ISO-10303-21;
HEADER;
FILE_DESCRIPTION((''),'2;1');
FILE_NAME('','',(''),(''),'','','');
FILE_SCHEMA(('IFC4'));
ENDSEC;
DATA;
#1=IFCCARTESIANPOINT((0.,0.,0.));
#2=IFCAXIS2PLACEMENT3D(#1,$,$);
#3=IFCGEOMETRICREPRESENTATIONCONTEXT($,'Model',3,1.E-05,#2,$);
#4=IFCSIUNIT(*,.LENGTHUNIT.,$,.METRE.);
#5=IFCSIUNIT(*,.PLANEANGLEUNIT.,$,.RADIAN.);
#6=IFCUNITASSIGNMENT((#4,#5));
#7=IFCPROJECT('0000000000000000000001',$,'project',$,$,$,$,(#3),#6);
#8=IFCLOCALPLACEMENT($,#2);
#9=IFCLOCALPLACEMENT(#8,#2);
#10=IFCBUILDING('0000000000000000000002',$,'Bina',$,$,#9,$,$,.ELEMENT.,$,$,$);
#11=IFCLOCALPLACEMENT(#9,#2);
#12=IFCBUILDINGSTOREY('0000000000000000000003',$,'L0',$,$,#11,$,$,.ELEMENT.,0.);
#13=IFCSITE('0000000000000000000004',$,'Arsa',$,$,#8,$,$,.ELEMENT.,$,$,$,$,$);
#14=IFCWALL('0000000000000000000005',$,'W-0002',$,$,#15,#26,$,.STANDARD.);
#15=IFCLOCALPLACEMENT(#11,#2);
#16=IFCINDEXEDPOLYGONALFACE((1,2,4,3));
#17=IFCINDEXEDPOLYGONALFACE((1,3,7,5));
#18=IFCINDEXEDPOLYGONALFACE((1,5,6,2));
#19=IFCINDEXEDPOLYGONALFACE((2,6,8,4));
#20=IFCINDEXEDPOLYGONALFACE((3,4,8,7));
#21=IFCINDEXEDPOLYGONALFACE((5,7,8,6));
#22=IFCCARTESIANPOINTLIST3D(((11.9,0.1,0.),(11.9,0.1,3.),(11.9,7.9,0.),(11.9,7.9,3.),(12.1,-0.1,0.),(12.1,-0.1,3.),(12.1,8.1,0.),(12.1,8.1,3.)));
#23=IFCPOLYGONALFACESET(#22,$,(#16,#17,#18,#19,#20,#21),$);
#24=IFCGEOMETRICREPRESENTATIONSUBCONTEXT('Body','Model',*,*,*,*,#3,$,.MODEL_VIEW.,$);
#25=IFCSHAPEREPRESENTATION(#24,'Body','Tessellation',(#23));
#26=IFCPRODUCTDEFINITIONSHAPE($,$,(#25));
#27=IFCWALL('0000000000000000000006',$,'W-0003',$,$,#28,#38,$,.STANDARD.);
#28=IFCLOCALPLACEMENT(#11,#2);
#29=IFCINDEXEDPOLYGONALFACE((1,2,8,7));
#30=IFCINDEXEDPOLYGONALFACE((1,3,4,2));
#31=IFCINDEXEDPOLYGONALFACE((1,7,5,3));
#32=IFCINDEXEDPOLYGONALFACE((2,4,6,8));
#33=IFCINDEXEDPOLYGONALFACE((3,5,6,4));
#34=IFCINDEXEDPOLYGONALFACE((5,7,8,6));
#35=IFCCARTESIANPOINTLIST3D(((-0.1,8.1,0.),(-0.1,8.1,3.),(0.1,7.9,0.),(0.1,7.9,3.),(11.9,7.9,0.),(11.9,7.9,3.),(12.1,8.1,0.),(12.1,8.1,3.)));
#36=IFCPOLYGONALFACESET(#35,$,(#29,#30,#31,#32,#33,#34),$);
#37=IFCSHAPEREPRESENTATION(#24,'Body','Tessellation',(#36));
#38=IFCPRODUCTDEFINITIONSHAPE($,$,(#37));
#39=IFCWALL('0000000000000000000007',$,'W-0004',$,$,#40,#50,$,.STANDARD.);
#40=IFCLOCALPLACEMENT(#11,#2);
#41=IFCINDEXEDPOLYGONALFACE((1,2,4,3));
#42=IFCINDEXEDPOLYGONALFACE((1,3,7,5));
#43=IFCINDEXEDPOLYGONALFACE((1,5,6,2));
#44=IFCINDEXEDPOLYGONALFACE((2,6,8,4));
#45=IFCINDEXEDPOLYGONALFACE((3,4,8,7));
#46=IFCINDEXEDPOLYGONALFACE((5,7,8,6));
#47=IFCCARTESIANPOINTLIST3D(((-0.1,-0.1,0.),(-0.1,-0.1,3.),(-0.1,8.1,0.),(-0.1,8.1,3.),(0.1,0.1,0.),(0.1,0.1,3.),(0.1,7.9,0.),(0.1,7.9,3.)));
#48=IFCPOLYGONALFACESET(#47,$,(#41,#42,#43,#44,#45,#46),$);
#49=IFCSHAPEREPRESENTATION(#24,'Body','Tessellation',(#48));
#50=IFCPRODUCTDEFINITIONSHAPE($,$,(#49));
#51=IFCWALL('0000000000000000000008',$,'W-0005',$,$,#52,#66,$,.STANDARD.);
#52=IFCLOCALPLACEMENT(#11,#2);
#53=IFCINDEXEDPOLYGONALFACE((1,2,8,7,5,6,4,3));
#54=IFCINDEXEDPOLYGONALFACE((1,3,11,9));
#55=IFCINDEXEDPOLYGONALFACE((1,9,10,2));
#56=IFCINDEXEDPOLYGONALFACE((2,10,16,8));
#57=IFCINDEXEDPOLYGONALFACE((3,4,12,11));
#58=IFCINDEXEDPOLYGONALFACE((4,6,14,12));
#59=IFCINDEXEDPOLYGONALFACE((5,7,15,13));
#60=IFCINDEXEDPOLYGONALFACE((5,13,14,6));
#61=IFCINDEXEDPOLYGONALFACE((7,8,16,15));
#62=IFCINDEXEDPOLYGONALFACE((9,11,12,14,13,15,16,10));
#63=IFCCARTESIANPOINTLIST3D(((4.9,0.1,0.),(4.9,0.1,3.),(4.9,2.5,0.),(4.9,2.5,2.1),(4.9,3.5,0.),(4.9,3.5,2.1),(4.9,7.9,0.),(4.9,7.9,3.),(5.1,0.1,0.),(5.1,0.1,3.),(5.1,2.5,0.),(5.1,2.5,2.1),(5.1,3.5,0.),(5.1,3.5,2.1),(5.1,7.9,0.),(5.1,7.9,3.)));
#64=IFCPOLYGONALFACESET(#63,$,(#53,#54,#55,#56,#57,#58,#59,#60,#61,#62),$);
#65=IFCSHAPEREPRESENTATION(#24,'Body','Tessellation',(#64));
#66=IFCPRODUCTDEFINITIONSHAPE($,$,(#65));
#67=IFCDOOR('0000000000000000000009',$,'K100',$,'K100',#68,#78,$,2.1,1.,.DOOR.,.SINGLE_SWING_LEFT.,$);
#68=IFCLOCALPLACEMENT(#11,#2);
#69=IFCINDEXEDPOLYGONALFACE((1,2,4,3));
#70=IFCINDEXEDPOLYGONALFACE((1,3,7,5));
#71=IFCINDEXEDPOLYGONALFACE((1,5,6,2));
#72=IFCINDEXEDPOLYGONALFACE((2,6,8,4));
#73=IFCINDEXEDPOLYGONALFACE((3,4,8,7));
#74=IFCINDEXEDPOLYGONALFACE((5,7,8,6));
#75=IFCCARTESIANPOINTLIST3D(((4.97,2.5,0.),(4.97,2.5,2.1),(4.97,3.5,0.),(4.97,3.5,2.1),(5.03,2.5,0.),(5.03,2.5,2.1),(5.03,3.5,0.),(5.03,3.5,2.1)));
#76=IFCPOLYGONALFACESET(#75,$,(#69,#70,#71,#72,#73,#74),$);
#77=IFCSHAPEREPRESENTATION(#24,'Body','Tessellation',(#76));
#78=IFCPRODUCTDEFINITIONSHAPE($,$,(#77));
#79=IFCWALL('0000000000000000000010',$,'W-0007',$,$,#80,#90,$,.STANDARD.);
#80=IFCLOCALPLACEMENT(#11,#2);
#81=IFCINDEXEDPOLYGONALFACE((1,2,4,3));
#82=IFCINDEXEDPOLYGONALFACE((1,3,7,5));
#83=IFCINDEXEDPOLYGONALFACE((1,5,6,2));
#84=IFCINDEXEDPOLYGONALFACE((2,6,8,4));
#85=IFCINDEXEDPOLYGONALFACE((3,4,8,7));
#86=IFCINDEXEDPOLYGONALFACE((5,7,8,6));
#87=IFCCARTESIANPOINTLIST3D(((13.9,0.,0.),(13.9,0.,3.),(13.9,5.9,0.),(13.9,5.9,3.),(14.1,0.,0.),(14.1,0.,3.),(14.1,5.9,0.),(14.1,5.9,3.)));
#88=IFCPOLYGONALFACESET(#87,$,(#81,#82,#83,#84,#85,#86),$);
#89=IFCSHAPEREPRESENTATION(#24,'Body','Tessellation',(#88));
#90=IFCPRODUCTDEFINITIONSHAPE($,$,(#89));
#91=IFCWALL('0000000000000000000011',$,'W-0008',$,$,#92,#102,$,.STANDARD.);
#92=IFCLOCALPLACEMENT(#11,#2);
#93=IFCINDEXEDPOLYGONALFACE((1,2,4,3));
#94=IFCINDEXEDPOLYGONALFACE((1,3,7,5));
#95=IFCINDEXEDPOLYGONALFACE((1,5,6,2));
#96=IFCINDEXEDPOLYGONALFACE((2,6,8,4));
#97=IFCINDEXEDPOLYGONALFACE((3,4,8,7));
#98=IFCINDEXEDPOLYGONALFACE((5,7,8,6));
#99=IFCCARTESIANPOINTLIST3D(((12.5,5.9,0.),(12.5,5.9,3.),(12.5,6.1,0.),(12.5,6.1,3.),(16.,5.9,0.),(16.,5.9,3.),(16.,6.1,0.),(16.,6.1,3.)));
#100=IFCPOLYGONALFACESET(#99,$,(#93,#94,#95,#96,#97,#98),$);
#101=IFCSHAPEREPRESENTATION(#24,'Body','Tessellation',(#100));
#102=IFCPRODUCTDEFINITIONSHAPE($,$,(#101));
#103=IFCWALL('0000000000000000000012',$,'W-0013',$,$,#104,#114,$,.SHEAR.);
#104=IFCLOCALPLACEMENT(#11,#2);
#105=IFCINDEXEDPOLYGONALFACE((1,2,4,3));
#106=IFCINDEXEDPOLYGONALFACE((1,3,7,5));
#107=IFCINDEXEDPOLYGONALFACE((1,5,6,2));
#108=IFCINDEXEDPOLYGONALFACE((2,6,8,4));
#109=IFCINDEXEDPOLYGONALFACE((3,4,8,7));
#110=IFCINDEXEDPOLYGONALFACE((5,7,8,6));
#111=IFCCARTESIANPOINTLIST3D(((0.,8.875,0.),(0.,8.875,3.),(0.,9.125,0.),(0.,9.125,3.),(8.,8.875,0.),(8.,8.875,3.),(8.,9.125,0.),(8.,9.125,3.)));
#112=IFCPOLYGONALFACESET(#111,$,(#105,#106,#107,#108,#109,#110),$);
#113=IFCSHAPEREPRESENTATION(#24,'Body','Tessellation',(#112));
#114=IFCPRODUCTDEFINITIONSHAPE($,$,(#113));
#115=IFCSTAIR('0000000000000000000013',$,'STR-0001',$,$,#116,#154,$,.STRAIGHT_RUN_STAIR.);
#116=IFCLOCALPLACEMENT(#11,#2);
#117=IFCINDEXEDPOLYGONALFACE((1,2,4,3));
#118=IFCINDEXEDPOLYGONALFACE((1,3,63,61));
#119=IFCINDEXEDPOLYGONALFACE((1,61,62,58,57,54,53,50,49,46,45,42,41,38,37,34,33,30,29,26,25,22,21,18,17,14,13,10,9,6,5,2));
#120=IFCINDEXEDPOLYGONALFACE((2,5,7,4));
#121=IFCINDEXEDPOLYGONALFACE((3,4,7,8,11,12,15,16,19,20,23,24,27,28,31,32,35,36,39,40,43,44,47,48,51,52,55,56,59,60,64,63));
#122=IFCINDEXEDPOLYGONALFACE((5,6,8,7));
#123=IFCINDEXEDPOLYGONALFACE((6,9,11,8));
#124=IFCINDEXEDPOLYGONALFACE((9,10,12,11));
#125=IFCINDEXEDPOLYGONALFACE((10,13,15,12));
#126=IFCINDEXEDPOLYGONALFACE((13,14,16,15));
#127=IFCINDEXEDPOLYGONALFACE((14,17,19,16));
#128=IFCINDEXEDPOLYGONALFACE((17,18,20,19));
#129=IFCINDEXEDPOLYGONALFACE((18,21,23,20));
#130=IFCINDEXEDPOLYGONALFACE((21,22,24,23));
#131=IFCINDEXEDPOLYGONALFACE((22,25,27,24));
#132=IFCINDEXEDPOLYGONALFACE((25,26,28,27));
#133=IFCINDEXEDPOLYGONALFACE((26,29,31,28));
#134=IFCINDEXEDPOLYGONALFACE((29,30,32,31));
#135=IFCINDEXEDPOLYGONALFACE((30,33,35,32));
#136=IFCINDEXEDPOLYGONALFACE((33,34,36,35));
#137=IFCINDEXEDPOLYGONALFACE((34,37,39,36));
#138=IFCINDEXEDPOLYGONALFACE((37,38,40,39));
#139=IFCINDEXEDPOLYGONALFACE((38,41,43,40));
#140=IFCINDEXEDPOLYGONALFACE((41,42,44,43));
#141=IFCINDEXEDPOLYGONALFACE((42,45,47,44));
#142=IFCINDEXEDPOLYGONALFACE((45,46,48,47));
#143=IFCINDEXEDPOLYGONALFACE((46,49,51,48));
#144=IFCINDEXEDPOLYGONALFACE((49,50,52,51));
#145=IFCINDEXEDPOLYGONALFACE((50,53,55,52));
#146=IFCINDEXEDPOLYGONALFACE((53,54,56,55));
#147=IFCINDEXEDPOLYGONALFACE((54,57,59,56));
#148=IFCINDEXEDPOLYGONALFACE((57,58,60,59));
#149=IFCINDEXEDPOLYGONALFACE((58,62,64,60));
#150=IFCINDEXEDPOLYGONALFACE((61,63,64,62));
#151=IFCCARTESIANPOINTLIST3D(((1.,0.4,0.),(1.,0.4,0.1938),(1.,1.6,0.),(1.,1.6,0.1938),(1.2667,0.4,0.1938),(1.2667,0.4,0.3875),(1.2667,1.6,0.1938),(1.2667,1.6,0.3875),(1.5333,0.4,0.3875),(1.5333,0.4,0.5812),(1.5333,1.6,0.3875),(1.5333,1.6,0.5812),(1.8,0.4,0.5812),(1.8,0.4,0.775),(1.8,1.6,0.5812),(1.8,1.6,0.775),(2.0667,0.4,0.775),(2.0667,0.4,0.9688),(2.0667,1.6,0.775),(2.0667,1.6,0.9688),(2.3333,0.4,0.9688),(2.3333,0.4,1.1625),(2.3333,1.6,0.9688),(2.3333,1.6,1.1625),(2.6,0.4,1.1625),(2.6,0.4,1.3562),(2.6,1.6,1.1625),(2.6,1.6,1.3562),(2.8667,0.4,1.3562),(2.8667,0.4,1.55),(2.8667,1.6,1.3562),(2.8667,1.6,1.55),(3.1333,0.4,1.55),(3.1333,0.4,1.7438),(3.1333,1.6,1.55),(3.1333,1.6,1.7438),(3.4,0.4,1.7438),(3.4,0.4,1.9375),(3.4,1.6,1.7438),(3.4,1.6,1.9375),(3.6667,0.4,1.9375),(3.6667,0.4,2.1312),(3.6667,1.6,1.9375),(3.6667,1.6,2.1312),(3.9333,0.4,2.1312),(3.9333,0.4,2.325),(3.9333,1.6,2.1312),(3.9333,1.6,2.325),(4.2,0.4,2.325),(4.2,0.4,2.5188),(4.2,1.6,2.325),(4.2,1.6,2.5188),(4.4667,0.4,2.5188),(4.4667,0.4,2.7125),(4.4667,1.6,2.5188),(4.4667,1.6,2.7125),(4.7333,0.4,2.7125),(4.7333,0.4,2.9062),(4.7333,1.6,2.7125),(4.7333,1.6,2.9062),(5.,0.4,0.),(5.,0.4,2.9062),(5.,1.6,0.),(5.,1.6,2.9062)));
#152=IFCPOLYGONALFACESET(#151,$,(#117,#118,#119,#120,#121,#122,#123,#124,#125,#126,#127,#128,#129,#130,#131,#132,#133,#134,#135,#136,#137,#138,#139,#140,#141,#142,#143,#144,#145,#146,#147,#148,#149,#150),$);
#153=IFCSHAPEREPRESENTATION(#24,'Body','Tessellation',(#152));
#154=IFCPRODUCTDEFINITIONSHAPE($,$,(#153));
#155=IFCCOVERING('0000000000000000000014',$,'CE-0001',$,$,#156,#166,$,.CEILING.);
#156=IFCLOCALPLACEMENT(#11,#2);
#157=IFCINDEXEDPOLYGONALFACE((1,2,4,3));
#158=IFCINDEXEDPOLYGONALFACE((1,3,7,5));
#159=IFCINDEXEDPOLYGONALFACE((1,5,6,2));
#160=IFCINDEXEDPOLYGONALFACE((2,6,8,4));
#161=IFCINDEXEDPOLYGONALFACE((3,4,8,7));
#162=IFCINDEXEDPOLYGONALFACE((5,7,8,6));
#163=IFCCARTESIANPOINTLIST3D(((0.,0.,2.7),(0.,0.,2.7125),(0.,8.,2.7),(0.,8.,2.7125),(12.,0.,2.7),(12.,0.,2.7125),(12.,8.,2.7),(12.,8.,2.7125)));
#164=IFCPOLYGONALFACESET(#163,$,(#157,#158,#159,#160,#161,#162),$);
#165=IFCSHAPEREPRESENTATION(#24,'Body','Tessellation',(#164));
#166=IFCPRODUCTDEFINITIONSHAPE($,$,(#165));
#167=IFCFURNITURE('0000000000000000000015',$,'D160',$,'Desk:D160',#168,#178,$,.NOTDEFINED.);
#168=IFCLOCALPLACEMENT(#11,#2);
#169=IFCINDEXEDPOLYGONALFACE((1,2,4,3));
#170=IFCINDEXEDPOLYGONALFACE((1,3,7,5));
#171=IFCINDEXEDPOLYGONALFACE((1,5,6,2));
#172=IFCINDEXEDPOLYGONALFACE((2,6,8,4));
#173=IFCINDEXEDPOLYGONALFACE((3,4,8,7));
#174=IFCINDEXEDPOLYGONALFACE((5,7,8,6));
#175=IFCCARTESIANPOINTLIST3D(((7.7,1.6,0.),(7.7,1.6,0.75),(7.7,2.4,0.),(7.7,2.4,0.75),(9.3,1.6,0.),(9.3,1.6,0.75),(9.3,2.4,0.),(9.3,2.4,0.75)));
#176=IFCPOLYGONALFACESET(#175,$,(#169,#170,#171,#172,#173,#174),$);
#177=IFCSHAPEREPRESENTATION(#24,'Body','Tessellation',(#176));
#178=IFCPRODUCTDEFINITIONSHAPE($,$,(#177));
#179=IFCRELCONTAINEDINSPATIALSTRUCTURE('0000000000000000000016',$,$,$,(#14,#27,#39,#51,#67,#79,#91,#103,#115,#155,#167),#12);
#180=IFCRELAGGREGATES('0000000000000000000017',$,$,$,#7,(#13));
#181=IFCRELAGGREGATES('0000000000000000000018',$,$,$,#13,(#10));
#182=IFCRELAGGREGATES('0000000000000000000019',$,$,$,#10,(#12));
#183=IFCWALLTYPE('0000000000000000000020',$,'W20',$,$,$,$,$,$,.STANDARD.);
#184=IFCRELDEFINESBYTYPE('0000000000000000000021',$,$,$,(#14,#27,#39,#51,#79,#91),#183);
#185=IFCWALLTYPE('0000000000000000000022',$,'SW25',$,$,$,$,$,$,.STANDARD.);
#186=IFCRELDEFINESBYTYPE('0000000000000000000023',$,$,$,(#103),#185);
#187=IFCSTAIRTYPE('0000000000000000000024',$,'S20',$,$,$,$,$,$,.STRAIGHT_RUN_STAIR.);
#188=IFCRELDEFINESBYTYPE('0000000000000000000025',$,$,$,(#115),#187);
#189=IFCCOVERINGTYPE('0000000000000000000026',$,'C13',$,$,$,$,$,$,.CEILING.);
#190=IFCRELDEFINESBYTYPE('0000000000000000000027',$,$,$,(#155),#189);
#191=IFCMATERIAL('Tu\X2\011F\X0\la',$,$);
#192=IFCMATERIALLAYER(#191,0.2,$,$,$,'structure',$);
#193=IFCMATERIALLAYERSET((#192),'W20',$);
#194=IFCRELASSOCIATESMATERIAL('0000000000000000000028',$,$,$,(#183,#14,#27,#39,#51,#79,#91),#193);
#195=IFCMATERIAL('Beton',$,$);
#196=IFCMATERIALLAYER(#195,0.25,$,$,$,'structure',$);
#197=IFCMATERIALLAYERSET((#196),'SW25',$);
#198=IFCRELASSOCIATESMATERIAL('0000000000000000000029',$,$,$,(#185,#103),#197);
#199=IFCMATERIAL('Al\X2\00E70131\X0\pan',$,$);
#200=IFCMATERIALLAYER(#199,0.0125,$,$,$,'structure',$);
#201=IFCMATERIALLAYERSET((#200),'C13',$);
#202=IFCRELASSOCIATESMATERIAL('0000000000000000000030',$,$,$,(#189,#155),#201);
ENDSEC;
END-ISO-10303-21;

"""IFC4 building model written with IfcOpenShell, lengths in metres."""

from ifc_helpers import new_model, si_unit, frame, origin, origin_2d, place, context, subcontext, project, spatial, polyline, rectangle, outline, extrude, material, layer, layer_set, layer_usage, type_object, element, fill, save


model = new_model("IFC4")

# Units and contexts
model_context = context("Model", 3, precision=1e-05, world=origin())
body_context = subcontext(model_context, "Body", "Model", "MODEL_VIEW")
ifc_project = project(units=[si_unit("LENGTHUNIT", "METRE"), si_unit("PLANEANGLEUNIT", "RADIAN")], contexts=[model_context])

# Site, building, storey
site_placement = place(None, origin())
site = spatial("IfcSite", under=ifc_project, at=site_placement, Name="Arsa", CompositionType="ELEMENT")
building_placement = place(site_placement, origin())
building = spatial("IfcBuilding", under=site, at=building_placement, Name="Bina", CompositionType="ELEMENT")
storey_placement = place(building_placement, origin())
storey = spatial("IfcBuildingStorey", under=building, at=storey_placement, Name="L0", CompositionType="ELEMENT", Elevation=0.0)

# Shared definitions
ifc_material_1 = material(Name="Beton")

# Shared definitions
ifc_material_2 = material(Name="Tuğla")
ifc_layer_1 = layer(ifc_material_2, 0.2, Category="structure")
ifc_layer_set_1 = layer_set([ifc_layer_1], Name="W20")
wall_type_1 = type_object("IfcWallType", Name="W20", PredefinedType="STANDARD", material=ifc_layer_set_1)

# Walls
ifc_layer_usage_1 = layer_usage(ifc_layer_set_1, "AXIS2", "POSITIVE", -0.1)
wall_1_placement = place(storey_placement, frame((12.0, 0.0, 0.0), z_axis=(0.0, 0.0, 1.0), x_axis=(0.0, 1.0, 0.0)))
element("IfcWall", 1, at=wall_1_placement, inside=storey, type_object=wall_type_1, material=ifc_layer_usage_1, Name="W-0002", PredefinedType="STANDARD", context=body_context, shape_type="SweptSolid", body=[
    extrude(outline(polyline([(0.1, 0.1), (7.9, 0.1), (8.1, -0.1), (-0.1, -0.1), (0.1, 0.1)])), origin(), (0.0, 0.0, 1.0), 3.0),
])
ifc_layer_usage_2 = layer_usage(ifc_layer_set_1, "AXIS2", "POSITIVE", -0.1)
wall_2_placement = place(storey_placement, frame((12.0, 8.0, 0.0), z_axis=(0.0, 0.0, 1.0), x_axis=(-1.0, 0.0, 0.0)))
element("IfcWall", 2, at=wall_2_placement, inside=storey, type_object=wall_type_1, material=ifc_layer_usage_2, Name="W-0003", PredefinedType="STANDARD", context=body_context, shape_type="SweptSolid", body=[
    extrude(outline(polyline([(0.1, 0.1), (11.9, 0.1), (12.1, -0.1), (-0.1, -0.1), (0.1, 0.1)])), origin(), (0.0, 0.0, 1.0), 3.0),
])
ifc_layer_usage_3 = layer_usage(ifc_layer_set_1, "AXIS2", "POSITIVE", -0.1)
wall_3_placement = place(storey_placement, frame((0.0, 8.0, 0.0), z_axis=(0.0, 0.0, 1.0), x_axis=(0.0, -1.0, 0.0)))
element("IfcWall", 3, at=wall_3_placement, inside=storey, type_object=wall_type_1, material=ifc_layer_usage_3, Name="W-0004", PredefinedType="STANDARD", context=body_context, shape_type="SweptSolid", body=[
    extrude(outline(polyline([(0.1, 0.1), (7.9, 0.1), (8.1, -0.1), (-0.1, -0.1), (0.1, 0.1)])), origin(), (0.0, 0.0, 1.0), 3.0),
])

# Wall, opening, door
ifc_layer_usage_4 = layer_usage(ifc_layer_set_1, "AXIS2", "POSITIVE", -0.1)
wall_4_placement = place(storey_placement, frame((5.0, 0.0, 0.0), z_axis=(0.0, 0.0, 1.0), x_axis=(0.0, 1.0, 0.0)))
wall_4 = element("IfcWall", 4, at=wall_4_placement, inside=storey, type_object=wall_type_1, material=ifc_layer_usage_4, Name="W-0005", PredefinedType="STANDARD", context=body_context, shape_type="SweptSolid", body=[
    extrude(outline(polyline([(0.1, 0.1), (7.9, 0.1), (7.9, -0.1), (0.1, -0.1), (0.1, 0.1)])), origin(), (0.0, 0.0, 1.0), 3.0),
])
opening_1_placement = place(wall_4_placement, frame((3.0, 0.0, 0.0)))
opening_1 = element("IfcOpeningElement", 5, at=opening_1_placement, cuts=wall_4, PredefinedType="OPENING", context=body_context, shape_type="SweptSolid", body=[
    extrude(rectangle(XDim=1.0, YDim=0.3, at=origin_2d()), origin(), (0.0, 0.0, 1.0), 2.1),
])
door_placement = place(opening_1_placement, origin())
door = element("IfcDoor", 6, at=door_placement, inside=storey, Name="K100", ObjectType="K100", OperationType="SINGLE_SWING_LEFT", OverallHeight=2.1, OverallWidth=1.0, PredefinedType="DOOR", context=body_context, shape_type="SweptSolid", body=[
    extrude(rectangle(XDim=1.0, YDim=0.06, at=origin_2d()), origin(), (0.0, 0.0, 1.0), 2.1),
])
fill(opening_1, door)

# Walls
ifc_layer_usage_5 = layer_usage(ifc_layer_set_1, "AXIS2", "POSITIVE", -0.1)
wall_5_placement = place(storey_placement, frame((14.0, 0.0, 0.0), z_axis=(0.0, 0.0, 1.0), x_axis=(0.0, 1.0, 0.0)))
element("IfcWall", 7, at=wall_5_placement, inside=storey, type_object=wall_type_1, material=ifc_layer_usage_5, Name="W-0007", PredefinedType="STANDARD", context=body_context, shape_type="SweptSolid", body=[
    extrude(outline(polyline([(0.0, 0.1), (5.9, 0.1), (5.9, -0.1), (0.0, -0.1), (0.0, 0.1)])), origin(), (0.0, 0.0, 1.0), 3.0),
])
ifc_layer_usage_6 = layer_usage(ifc_layer_set_1, "AXIS2", "POSITIVE", -0.1)
wall_6_placement = place(storey_placement, frame((12.5, 6.0, 0.0), z_axis=(0.0, 0.0, 1.0), x_axis=(1.0, 0.0, 0.0)))
element("IfcWall", 8, at=wall_6_placement, inside=storey, type_object=wall_type_1, material=ifc_layer_usage_6, Name="W-0008", PredefinedType="STANDARD", context=body_context, shape_type="SweptSolid", body=[
    extrude(outline(polyline([(0.0, 0.1), (3.5, 0.1), (3.5, -0.1), (0.0, -0.1), (0.0, 0.1)])), origin(), (0.0, 0.0, 1.0), 3.0),
])
ifc_layer_2 = layer(ifc_material_1, 0.25, Category="structure")
ifc_layer_set_2 = layer_set([ifc_layer_2], Name="SW25")
ifc_layer_usage_7 = layer_usage(ifc_layer_set_2, "AXIS2", "POSITIVE", -0.125)
wall_type_2 = type_object("IfcWallType", Name="SW25", PredefinedType="STANDARD", material=ifc_layer_set_2)
wall_7_placement = place(storey_placement, frame((0.0, 9.0, 0.0), z_axis=(0.0, 0.0, 1.0), x_axis=(1.0, 0.0, 0.0)))
element("IfcWall", 9, at=wall_7_placement, inside=storey, type_object=wall_type_2, material=ifc_layer_usage_7, Name="W-0013", PredefinedType="SHEAR", context=body_context, shape_type="SweptSolid", body=[
    extrude(outline(polyline([(0.0, 0.125), (8.0, 0.125), (8.0, -0.125), (0.0, -0.125), (0.0, 0.125)])), origin(), (0.0, 0.0, 1.0), 3.0),
])

# Stair
stair_type = type_object("IfcStairType", Name="S20", PredefinedType="STRAIGHT_RUN_STAIR")
stair_placement = place(storey_placement, origin())
element("IfcStair", 10, at=stair_placement, inside=storey, type_object=stair_type, Name="STR-0001", PredefinedType="STRAIGHT_RUN_STAIR", context=body_context, shape_type="SweptSolid", body=[
    extrude(outline(polyline([(0.0, 0.0), (0.0, 0.1938), (0.2667, 0.1938), (0.2667, 0.3875), (0.5333, 0.3875), (0.5333, 0.5813), (0.8, 0.5813), (0.8, 0.775), (1.0667, 0.775), (1.0667, 0.9688), (1.3333, 0.9688), (1.3333, 1.1625), (1.6, 1.1625), (1.6, 1.3562), (1.8667, 1.3562), (1.8667, 1.55), (2.1333, 1.55), (2.1333, 1.7437), (2.4, 1.7437), (2.4, 1.9375), (2.6667, 1.9375), (2.6667, 2.1313), (2.9333, 2.1313), (2.9333, 2.325), (3.2, 2.325), (3.2, 2.5187), (3.4667, 2.5187), (3.4667, 2.7125), (3.7333, 2.7125), (3.7333, 2.9062), (4.0, 2.9062), (4.0, 0.0), (0.0, 0.0)])), frame((1.0, 1.6, 0.0), z_axis=(0.0, -1.0, 0.0), x_axis=(1.0, 0.0, 0.0)), (0.0, 0.0, 1.0), 1.2),
])

# Covering
ifc_material_3 = material(Name="Alçıpan")
ifc_layer_3 = layer(ifc_material_3, 0.0125, Category="structure")
ifc_layer_set_3 = layer_set([ifc_layer_3], Name="C13")
ifc_layer_usage_8 = layer_usage(ifc_layer_set_3, "AXIS3", "POSITIVE", 2.7)
covering_type = type_object("IfcCoveringType", Name="C13", PredefinedType="CEILING", material=ifc_layer_set_3)
covering_placement = place(storey_placement, origin())
element("IfcCovering", 11, at=covering_placement, inside=storey, type_object=covering_type, material=ifc_layer_usage_8, Name="CE-0001", PredefinedType="CEILING", context=body_context, shape_type="SweptSolid", body=[
    extrude(outline(polyline([(0.0, 0.0), (12.0, 0.0), (12.0, 8.0), (0.0, 8.0), (0.0, 0.0)])), frame((0.0, 0.0, 2.7)), (0.0, 0.0, 1.0), 0.0125),
])

# Furniture
furniture_placement = place(storey_placement, frame((8.5, 2.0, 0.0), z_axis=(0.0, 0.0, 1.0), x_axis=(1.0, 0.0, 0.0)))
element("IfcFurniture", 12, at=furniture_placement, inside=storey, Name="D160", ObjectType="Desk:D160", PredefinedType="NOTDEFINED", context=body_context, shape_type="SweptSolid", body=[
    extrude(rectangle(XDim=1.6, YDim=0.8, at=origin_2d()), origin(), (0.0, 0.0, 1.0), 0.75),
])

save(model, "model.ifc")
